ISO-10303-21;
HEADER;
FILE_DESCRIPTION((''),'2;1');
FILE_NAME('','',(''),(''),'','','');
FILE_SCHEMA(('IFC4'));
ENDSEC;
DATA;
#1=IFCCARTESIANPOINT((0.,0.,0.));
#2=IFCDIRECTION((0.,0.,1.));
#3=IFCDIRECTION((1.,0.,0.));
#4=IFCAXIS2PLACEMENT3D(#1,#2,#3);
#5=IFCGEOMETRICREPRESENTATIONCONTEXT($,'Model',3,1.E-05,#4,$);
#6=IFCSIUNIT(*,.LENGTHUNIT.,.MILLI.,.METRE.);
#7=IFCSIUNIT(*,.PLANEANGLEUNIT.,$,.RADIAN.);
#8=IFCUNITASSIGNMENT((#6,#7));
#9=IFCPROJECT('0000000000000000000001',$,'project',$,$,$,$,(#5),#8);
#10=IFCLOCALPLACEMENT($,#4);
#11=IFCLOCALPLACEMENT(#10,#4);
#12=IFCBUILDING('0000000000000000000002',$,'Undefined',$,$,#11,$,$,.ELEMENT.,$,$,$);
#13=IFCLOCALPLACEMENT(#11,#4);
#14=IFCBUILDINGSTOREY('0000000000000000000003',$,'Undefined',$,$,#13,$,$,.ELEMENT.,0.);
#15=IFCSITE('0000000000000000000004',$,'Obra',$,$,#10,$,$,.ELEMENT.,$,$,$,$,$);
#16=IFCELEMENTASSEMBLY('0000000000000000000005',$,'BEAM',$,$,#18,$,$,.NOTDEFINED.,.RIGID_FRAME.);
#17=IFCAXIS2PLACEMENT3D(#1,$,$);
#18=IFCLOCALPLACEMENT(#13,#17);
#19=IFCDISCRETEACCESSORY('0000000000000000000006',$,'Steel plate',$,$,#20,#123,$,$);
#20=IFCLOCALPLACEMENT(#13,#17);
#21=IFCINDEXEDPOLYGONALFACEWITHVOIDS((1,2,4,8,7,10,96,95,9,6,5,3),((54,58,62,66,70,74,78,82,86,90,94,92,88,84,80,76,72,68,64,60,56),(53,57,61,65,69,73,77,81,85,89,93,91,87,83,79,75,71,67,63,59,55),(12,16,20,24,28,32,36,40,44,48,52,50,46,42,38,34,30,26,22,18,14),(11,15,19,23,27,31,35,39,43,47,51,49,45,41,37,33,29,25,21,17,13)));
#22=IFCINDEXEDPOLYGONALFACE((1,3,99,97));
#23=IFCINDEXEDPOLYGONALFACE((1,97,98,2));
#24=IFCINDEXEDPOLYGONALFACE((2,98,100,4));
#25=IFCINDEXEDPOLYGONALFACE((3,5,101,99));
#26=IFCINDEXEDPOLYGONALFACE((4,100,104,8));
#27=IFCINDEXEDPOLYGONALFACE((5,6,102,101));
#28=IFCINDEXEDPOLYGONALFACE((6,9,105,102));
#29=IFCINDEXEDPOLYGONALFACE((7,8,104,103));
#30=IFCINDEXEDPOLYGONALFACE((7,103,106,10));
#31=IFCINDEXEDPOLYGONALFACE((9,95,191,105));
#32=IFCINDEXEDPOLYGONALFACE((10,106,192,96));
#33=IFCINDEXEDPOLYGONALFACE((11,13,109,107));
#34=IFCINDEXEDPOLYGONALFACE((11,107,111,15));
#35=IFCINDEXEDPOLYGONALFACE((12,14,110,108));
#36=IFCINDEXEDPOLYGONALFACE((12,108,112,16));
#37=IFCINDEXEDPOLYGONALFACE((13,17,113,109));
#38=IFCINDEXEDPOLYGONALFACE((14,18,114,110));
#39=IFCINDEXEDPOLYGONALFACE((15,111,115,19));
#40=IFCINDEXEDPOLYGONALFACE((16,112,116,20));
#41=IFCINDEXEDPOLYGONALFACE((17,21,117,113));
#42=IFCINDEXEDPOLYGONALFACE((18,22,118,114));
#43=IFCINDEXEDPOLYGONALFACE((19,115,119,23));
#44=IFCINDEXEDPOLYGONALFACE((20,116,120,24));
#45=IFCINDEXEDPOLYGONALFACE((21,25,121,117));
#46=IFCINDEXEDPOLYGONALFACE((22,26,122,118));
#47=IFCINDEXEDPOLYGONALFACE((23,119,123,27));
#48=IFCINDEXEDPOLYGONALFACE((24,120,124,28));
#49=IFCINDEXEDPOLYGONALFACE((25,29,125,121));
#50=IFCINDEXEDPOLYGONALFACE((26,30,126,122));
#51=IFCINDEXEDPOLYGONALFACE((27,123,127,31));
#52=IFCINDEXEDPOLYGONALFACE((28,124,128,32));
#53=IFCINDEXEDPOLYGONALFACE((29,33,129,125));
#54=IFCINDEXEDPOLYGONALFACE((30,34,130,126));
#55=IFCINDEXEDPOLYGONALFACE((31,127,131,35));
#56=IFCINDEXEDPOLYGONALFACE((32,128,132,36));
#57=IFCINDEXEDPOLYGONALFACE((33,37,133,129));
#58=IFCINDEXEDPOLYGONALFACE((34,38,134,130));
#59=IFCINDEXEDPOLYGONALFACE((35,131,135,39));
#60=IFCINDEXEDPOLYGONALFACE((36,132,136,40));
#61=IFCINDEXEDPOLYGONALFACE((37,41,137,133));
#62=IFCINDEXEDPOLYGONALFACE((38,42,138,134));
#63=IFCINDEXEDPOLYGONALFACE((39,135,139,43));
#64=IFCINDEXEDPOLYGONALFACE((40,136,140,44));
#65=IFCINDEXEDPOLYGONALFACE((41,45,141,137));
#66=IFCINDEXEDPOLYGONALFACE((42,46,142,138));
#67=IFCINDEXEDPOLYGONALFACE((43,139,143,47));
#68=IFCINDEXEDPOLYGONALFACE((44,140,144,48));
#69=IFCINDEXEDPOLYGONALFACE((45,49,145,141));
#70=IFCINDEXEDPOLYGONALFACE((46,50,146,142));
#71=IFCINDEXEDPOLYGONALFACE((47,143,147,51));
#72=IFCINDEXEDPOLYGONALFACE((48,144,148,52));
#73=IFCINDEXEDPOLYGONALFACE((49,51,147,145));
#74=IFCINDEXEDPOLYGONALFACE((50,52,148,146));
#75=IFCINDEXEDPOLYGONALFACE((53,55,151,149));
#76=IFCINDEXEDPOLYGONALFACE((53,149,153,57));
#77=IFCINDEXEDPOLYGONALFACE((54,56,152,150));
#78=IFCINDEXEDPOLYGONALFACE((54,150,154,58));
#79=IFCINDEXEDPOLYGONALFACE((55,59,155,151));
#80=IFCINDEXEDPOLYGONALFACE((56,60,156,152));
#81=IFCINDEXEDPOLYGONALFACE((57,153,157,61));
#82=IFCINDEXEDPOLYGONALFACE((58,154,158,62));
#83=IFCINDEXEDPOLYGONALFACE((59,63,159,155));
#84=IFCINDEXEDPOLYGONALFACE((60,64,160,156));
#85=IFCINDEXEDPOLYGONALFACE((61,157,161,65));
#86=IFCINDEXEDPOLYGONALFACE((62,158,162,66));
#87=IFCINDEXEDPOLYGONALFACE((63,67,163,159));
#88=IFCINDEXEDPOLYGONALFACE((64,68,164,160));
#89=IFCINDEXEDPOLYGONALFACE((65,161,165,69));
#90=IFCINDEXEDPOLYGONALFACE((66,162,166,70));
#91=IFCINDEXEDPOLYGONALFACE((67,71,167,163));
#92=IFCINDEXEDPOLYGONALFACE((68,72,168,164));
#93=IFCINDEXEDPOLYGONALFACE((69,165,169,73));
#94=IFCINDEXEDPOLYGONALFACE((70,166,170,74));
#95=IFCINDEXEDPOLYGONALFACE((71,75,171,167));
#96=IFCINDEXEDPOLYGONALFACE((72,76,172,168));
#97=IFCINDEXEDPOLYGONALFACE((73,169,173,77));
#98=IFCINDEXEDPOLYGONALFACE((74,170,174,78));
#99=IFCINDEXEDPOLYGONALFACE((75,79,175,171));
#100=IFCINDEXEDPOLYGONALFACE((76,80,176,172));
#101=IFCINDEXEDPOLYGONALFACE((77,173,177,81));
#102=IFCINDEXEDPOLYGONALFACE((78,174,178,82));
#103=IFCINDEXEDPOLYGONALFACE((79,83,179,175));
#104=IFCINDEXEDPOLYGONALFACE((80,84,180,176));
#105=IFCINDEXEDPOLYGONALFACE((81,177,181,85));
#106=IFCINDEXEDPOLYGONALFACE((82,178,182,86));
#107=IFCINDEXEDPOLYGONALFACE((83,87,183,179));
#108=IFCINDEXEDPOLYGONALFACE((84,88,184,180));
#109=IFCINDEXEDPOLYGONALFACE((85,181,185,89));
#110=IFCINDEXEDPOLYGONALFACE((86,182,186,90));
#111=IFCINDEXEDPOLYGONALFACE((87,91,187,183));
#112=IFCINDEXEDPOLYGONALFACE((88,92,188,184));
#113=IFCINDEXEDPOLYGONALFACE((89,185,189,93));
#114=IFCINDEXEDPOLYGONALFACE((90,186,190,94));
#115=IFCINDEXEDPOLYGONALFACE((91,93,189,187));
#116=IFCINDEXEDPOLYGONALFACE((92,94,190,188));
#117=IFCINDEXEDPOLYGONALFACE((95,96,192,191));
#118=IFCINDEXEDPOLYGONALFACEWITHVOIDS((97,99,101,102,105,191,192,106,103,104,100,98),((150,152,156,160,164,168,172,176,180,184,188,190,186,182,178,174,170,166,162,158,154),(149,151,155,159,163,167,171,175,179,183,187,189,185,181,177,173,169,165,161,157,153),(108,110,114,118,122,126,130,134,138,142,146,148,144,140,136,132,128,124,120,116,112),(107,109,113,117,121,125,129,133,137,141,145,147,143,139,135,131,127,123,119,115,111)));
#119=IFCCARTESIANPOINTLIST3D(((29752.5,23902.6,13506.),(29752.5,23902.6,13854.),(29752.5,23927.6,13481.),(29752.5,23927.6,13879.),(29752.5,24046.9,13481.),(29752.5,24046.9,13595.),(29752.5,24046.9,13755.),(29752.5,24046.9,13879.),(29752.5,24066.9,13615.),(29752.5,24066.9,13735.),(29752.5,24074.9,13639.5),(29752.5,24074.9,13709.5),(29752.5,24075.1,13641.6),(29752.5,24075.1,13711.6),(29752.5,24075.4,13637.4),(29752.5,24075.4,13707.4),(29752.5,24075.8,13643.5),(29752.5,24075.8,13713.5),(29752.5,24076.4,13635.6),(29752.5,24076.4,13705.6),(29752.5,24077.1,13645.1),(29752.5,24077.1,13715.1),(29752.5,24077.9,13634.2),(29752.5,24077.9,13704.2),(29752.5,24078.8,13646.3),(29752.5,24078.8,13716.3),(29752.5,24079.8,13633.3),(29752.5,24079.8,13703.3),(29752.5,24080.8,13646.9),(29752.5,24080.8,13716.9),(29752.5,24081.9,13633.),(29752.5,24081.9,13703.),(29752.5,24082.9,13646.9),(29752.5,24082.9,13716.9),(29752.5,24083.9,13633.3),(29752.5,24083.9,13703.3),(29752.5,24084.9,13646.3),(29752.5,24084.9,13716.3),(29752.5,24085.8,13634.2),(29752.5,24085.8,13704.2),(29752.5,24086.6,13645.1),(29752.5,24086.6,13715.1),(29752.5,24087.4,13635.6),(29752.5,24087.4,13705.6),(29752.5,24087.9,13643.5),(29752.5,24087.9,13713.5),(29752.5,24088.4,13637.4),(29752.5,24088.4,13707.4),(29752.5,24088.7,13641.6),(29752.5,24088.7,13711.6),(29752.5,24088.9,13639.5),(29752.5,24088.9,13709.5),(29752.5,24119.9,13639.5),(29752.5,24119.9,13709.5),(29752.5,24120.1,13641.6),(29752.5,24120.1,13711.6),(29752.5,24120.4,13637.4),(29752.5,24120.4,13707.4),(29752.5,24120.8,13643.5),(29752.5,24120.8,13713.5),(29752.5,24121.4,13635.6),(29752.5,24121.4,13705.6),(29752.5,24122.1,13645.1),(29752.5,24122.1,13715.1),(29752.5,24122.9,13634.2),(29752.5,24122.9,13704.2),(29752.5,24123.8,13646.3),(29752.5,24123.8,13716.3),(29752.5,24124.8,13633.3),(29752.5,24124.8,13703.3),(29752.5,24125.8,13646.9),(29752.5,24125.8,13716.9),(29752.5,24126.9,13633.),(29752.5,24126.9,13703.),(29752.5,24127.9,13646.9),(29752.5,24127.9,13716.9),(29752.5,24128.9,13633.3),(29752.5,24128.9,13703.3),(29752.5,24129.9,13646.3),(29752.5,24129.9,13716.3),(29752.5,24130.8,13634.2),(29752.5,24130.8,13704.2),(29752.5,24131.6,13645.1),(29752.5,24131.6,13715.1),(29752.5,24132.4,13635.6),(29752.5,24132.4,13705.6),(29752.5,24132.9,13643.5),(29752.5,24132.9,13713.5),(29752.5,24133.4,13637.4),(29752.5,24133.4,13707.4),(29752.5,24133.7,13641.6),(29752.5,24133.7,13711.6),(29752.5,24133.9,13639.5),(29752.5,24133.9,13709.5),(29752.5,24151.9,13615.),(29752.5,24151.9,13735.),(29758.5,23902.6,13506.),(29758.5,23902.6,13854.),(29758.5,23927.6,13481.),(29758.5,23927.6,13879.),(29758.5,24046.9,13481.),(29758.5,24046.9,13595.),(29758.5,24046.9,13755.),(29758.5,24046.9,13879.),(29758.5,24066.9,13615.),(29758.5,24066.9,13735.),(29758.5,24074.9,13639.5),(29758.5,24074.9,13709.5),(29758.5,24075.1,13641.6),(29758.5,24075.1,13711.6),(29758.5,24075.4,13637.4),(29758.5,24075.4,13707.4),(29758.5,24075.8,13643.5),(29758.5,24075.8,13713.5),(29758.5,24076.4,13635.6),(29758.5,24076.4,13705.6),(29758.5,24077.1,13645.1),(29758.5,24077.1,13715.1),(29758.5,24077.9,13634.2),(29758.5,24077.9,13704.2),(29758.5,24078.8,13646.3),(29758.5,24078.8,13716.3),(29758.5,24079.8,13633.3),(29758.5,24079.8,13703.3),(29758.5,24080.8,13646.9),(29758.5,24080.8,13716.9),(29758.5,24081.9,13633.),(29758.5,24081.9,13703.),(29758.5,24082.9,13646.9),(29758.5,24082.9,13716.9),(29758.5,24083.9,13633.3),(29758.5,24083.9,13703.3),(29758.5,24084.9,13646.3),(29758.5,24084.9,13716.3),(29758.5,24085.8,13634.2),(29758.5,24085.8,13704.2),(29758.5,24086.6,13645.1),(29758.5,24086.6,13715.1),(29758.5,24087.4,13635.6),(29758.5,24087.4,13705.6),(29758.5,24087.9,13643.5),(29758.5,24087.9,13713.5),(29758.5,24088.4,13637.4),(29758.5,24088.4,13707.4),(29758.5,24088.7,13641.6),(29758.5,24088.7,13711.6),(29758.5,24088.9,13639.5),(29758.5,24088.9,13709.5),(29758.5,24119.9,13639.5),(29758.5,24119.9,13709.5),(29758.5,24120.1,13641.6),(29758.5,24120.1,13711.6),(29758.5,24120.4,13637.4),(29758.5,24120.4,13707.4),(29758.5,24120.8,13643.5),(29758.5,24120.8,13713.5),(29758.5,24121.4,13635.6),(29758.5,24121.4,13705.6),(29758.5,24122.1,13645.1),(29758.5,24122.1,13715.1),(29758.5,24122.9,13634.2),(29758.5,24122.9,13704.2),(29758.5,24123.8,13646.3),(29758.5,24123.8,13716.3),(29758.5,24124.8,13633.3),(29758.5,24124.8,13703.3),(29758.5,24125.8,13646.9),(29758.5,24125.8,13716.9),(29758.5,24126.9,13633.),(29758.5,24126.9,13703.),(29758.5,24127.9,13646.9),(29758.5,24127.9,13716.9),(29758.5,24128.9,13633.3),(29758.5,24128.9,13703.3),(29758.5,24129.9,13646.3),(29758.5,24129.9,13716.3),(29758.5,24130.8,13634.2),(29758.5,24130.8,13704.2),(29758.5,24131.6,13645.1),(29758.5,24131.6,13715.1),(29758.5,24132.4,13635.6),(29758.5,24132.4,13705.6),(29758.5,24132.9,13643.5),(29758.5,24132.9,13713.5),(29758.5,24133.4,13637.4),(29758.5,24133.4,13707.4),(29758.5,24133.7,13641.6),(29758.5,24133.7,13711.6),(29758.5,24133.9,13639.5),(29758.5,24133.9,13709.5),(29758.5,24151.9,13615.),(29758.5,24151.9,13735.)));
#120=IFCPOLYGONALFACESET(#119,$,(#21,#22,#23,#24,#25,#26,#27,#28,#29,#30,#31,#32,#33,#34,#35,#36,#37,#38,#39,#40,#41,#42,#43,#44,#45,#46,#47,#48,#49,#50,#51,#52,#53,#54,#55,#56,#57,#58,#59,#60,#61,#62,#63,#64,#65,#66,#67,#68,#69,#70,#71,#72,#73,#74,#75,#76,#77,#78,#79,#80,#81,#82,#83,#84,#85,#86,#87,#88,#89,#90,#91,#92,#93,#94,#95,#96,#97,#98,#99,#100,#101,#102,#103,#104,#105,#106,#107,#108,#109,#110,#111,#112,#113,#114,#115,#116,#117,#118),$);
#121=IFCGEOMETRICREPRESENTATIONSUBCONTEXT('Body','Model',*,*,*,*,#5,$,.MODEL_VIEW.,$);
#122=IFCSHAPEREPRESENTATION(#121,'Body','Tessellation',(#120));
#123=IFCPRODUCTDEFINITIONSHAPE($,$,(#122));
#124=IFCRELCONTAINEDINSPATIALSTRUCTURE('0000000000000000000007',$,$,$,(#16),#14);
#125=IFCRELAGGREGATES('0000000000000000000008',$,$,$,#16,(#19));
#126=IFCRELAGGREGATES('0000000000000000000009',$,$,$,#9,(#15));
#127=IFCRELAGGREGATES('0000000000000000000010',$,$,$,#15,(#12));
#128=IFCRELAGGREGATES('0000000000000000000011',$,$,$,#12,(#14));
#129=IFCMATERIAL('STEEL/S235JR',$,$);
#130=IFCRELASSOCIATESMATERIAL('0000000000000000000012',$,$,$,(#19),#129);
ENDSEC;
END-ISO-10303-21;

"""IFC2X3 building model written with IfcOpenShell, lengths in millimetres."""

from ifc_helpers import new_model, si_unit, frame, origin_with_axes, origin_2d_with_axis, place, context, subcontext, project, spatial, polyline, circle, outline, extrude, source, transform, mapped, material, element, aggregate, save


model = new_model("IFC2X3")

# Units and contexts
model_context = context("Model", 3, precision=1e-05, world=origin_with_axes())
body_context = subcontext(model_context, "Body", "Model", "MODEL_VIEW")
ifc_project = project(units=[si_unit("LENGTHUNIT", "METRE", prefix="MILLI"), si_unit("PLANEANGLEUNIT", "RADIAN")], contexts=[model_context])

# Site, building, storey
site_placement = place(None, origin_with_axes())
site = spatial("IfcSite", under=ifc_project, at=site_placement, Name="Obra", CompositionType="ELEMENT")
building_placement = place(site_placement, origin_with_axes())
building = spatial("IfcBuilding", under=site, at=building_placement, Name="Undefined", CompositionType="ELEMENT")
storey_placement = place(building_placement, origin_with_axes())
storey = spatial("IfcBuildingStorey", under=building, at=storey_placement, Name="Undefined", CompositionType="ELEMENT", Elevation=0.0)

# Shared definitions
ifc_material_1 = material(Name="STEEL/S235JR")

# Element assembly, discrete accessory, opening
assembly_1_placement = place(storey_placement, origin_with_axes())
assembly_1 = element("IfcElementAssembly", 1, at=assembly_1_placement, inside=storey, Name="BEAM", AssemblyPlace="NOTDEFINED", PredefinedType="RIGID_FRAME")
shared_shape_1 = source(origin_with_axes(), body_context, "Body", "SweptSolid", [
    extrude(circle(Radius=7.0, at=origin_2d_with_axis()), frame((0.0, -8.6, 0.0), z_axis=(0.0, 1.0, 0.0), x_axis=(1.0, 0.0, 0.0)), (0.0, 0.0, 1.0), 6.2),
])
discrete_accessory_1_placement = place(assembly_1_placement, frame((29755.5, 23902.6, 13506.0), z_axis=(1.0, 0.0, 0.0), x_axis=(-0.000001, 0.707107, -0.707107)))
discrete_accessory_1 = element("IfcDiscreteAccessory", 2, at=discrete_accessory_1_placement, material=ifc_material_1, Name="Steel plate", context=body_context, shape_type="SweptSolid", body=[
    extrude(outline(polyline([(0.0, 0.0), (35.4, 0.0), (119.7, 84.3), (39.1, 164.9), (39.1, 193.2), (99.2, 253.3), (14.3, 338.2), (-45.8, 278.1), (-74.1, 278.1), (-161.8, 365.8), (-246.1, 281.4), (-246.1, 246.1), (0.0, 0.0)])), frame((0.0, 0.0, -3.0), z_axis=(0.0, 0.0, 1.0), x_axis=(1.0, 0.0, 0.0)), (0.0, 0.0, 1.0), 6.0),
])
opening_1_placement = place(assembly_1_placement, frame((29750.0, 24056.9, 13735.0), z_axis=(0.0, 1.0, 0.0), x_axis=(0.0, 0.0, -1.0)))
element("IfcOpeningElement", 3, at=opening_1_placement, cuts=discrete_accessory_1, ObjectType="Opening", context=body_context, shape_type="MappedRepresentation", body=[
    mapped(shared_shape_1, transform((25.0, 0.0, 25.0))),
    mapped(shared_shape_1, transform((25.0, 0.0, 70.0))),
    mapped(shared_shape_1, transform((95.0, 0.0, 25.0))),
    mapped(shared_shape_1, transform((95.0, 0.0, 70.0))),
])
aggregate(assembly_1, [discrete_accessory_1])

save(model, "model.ifc")
